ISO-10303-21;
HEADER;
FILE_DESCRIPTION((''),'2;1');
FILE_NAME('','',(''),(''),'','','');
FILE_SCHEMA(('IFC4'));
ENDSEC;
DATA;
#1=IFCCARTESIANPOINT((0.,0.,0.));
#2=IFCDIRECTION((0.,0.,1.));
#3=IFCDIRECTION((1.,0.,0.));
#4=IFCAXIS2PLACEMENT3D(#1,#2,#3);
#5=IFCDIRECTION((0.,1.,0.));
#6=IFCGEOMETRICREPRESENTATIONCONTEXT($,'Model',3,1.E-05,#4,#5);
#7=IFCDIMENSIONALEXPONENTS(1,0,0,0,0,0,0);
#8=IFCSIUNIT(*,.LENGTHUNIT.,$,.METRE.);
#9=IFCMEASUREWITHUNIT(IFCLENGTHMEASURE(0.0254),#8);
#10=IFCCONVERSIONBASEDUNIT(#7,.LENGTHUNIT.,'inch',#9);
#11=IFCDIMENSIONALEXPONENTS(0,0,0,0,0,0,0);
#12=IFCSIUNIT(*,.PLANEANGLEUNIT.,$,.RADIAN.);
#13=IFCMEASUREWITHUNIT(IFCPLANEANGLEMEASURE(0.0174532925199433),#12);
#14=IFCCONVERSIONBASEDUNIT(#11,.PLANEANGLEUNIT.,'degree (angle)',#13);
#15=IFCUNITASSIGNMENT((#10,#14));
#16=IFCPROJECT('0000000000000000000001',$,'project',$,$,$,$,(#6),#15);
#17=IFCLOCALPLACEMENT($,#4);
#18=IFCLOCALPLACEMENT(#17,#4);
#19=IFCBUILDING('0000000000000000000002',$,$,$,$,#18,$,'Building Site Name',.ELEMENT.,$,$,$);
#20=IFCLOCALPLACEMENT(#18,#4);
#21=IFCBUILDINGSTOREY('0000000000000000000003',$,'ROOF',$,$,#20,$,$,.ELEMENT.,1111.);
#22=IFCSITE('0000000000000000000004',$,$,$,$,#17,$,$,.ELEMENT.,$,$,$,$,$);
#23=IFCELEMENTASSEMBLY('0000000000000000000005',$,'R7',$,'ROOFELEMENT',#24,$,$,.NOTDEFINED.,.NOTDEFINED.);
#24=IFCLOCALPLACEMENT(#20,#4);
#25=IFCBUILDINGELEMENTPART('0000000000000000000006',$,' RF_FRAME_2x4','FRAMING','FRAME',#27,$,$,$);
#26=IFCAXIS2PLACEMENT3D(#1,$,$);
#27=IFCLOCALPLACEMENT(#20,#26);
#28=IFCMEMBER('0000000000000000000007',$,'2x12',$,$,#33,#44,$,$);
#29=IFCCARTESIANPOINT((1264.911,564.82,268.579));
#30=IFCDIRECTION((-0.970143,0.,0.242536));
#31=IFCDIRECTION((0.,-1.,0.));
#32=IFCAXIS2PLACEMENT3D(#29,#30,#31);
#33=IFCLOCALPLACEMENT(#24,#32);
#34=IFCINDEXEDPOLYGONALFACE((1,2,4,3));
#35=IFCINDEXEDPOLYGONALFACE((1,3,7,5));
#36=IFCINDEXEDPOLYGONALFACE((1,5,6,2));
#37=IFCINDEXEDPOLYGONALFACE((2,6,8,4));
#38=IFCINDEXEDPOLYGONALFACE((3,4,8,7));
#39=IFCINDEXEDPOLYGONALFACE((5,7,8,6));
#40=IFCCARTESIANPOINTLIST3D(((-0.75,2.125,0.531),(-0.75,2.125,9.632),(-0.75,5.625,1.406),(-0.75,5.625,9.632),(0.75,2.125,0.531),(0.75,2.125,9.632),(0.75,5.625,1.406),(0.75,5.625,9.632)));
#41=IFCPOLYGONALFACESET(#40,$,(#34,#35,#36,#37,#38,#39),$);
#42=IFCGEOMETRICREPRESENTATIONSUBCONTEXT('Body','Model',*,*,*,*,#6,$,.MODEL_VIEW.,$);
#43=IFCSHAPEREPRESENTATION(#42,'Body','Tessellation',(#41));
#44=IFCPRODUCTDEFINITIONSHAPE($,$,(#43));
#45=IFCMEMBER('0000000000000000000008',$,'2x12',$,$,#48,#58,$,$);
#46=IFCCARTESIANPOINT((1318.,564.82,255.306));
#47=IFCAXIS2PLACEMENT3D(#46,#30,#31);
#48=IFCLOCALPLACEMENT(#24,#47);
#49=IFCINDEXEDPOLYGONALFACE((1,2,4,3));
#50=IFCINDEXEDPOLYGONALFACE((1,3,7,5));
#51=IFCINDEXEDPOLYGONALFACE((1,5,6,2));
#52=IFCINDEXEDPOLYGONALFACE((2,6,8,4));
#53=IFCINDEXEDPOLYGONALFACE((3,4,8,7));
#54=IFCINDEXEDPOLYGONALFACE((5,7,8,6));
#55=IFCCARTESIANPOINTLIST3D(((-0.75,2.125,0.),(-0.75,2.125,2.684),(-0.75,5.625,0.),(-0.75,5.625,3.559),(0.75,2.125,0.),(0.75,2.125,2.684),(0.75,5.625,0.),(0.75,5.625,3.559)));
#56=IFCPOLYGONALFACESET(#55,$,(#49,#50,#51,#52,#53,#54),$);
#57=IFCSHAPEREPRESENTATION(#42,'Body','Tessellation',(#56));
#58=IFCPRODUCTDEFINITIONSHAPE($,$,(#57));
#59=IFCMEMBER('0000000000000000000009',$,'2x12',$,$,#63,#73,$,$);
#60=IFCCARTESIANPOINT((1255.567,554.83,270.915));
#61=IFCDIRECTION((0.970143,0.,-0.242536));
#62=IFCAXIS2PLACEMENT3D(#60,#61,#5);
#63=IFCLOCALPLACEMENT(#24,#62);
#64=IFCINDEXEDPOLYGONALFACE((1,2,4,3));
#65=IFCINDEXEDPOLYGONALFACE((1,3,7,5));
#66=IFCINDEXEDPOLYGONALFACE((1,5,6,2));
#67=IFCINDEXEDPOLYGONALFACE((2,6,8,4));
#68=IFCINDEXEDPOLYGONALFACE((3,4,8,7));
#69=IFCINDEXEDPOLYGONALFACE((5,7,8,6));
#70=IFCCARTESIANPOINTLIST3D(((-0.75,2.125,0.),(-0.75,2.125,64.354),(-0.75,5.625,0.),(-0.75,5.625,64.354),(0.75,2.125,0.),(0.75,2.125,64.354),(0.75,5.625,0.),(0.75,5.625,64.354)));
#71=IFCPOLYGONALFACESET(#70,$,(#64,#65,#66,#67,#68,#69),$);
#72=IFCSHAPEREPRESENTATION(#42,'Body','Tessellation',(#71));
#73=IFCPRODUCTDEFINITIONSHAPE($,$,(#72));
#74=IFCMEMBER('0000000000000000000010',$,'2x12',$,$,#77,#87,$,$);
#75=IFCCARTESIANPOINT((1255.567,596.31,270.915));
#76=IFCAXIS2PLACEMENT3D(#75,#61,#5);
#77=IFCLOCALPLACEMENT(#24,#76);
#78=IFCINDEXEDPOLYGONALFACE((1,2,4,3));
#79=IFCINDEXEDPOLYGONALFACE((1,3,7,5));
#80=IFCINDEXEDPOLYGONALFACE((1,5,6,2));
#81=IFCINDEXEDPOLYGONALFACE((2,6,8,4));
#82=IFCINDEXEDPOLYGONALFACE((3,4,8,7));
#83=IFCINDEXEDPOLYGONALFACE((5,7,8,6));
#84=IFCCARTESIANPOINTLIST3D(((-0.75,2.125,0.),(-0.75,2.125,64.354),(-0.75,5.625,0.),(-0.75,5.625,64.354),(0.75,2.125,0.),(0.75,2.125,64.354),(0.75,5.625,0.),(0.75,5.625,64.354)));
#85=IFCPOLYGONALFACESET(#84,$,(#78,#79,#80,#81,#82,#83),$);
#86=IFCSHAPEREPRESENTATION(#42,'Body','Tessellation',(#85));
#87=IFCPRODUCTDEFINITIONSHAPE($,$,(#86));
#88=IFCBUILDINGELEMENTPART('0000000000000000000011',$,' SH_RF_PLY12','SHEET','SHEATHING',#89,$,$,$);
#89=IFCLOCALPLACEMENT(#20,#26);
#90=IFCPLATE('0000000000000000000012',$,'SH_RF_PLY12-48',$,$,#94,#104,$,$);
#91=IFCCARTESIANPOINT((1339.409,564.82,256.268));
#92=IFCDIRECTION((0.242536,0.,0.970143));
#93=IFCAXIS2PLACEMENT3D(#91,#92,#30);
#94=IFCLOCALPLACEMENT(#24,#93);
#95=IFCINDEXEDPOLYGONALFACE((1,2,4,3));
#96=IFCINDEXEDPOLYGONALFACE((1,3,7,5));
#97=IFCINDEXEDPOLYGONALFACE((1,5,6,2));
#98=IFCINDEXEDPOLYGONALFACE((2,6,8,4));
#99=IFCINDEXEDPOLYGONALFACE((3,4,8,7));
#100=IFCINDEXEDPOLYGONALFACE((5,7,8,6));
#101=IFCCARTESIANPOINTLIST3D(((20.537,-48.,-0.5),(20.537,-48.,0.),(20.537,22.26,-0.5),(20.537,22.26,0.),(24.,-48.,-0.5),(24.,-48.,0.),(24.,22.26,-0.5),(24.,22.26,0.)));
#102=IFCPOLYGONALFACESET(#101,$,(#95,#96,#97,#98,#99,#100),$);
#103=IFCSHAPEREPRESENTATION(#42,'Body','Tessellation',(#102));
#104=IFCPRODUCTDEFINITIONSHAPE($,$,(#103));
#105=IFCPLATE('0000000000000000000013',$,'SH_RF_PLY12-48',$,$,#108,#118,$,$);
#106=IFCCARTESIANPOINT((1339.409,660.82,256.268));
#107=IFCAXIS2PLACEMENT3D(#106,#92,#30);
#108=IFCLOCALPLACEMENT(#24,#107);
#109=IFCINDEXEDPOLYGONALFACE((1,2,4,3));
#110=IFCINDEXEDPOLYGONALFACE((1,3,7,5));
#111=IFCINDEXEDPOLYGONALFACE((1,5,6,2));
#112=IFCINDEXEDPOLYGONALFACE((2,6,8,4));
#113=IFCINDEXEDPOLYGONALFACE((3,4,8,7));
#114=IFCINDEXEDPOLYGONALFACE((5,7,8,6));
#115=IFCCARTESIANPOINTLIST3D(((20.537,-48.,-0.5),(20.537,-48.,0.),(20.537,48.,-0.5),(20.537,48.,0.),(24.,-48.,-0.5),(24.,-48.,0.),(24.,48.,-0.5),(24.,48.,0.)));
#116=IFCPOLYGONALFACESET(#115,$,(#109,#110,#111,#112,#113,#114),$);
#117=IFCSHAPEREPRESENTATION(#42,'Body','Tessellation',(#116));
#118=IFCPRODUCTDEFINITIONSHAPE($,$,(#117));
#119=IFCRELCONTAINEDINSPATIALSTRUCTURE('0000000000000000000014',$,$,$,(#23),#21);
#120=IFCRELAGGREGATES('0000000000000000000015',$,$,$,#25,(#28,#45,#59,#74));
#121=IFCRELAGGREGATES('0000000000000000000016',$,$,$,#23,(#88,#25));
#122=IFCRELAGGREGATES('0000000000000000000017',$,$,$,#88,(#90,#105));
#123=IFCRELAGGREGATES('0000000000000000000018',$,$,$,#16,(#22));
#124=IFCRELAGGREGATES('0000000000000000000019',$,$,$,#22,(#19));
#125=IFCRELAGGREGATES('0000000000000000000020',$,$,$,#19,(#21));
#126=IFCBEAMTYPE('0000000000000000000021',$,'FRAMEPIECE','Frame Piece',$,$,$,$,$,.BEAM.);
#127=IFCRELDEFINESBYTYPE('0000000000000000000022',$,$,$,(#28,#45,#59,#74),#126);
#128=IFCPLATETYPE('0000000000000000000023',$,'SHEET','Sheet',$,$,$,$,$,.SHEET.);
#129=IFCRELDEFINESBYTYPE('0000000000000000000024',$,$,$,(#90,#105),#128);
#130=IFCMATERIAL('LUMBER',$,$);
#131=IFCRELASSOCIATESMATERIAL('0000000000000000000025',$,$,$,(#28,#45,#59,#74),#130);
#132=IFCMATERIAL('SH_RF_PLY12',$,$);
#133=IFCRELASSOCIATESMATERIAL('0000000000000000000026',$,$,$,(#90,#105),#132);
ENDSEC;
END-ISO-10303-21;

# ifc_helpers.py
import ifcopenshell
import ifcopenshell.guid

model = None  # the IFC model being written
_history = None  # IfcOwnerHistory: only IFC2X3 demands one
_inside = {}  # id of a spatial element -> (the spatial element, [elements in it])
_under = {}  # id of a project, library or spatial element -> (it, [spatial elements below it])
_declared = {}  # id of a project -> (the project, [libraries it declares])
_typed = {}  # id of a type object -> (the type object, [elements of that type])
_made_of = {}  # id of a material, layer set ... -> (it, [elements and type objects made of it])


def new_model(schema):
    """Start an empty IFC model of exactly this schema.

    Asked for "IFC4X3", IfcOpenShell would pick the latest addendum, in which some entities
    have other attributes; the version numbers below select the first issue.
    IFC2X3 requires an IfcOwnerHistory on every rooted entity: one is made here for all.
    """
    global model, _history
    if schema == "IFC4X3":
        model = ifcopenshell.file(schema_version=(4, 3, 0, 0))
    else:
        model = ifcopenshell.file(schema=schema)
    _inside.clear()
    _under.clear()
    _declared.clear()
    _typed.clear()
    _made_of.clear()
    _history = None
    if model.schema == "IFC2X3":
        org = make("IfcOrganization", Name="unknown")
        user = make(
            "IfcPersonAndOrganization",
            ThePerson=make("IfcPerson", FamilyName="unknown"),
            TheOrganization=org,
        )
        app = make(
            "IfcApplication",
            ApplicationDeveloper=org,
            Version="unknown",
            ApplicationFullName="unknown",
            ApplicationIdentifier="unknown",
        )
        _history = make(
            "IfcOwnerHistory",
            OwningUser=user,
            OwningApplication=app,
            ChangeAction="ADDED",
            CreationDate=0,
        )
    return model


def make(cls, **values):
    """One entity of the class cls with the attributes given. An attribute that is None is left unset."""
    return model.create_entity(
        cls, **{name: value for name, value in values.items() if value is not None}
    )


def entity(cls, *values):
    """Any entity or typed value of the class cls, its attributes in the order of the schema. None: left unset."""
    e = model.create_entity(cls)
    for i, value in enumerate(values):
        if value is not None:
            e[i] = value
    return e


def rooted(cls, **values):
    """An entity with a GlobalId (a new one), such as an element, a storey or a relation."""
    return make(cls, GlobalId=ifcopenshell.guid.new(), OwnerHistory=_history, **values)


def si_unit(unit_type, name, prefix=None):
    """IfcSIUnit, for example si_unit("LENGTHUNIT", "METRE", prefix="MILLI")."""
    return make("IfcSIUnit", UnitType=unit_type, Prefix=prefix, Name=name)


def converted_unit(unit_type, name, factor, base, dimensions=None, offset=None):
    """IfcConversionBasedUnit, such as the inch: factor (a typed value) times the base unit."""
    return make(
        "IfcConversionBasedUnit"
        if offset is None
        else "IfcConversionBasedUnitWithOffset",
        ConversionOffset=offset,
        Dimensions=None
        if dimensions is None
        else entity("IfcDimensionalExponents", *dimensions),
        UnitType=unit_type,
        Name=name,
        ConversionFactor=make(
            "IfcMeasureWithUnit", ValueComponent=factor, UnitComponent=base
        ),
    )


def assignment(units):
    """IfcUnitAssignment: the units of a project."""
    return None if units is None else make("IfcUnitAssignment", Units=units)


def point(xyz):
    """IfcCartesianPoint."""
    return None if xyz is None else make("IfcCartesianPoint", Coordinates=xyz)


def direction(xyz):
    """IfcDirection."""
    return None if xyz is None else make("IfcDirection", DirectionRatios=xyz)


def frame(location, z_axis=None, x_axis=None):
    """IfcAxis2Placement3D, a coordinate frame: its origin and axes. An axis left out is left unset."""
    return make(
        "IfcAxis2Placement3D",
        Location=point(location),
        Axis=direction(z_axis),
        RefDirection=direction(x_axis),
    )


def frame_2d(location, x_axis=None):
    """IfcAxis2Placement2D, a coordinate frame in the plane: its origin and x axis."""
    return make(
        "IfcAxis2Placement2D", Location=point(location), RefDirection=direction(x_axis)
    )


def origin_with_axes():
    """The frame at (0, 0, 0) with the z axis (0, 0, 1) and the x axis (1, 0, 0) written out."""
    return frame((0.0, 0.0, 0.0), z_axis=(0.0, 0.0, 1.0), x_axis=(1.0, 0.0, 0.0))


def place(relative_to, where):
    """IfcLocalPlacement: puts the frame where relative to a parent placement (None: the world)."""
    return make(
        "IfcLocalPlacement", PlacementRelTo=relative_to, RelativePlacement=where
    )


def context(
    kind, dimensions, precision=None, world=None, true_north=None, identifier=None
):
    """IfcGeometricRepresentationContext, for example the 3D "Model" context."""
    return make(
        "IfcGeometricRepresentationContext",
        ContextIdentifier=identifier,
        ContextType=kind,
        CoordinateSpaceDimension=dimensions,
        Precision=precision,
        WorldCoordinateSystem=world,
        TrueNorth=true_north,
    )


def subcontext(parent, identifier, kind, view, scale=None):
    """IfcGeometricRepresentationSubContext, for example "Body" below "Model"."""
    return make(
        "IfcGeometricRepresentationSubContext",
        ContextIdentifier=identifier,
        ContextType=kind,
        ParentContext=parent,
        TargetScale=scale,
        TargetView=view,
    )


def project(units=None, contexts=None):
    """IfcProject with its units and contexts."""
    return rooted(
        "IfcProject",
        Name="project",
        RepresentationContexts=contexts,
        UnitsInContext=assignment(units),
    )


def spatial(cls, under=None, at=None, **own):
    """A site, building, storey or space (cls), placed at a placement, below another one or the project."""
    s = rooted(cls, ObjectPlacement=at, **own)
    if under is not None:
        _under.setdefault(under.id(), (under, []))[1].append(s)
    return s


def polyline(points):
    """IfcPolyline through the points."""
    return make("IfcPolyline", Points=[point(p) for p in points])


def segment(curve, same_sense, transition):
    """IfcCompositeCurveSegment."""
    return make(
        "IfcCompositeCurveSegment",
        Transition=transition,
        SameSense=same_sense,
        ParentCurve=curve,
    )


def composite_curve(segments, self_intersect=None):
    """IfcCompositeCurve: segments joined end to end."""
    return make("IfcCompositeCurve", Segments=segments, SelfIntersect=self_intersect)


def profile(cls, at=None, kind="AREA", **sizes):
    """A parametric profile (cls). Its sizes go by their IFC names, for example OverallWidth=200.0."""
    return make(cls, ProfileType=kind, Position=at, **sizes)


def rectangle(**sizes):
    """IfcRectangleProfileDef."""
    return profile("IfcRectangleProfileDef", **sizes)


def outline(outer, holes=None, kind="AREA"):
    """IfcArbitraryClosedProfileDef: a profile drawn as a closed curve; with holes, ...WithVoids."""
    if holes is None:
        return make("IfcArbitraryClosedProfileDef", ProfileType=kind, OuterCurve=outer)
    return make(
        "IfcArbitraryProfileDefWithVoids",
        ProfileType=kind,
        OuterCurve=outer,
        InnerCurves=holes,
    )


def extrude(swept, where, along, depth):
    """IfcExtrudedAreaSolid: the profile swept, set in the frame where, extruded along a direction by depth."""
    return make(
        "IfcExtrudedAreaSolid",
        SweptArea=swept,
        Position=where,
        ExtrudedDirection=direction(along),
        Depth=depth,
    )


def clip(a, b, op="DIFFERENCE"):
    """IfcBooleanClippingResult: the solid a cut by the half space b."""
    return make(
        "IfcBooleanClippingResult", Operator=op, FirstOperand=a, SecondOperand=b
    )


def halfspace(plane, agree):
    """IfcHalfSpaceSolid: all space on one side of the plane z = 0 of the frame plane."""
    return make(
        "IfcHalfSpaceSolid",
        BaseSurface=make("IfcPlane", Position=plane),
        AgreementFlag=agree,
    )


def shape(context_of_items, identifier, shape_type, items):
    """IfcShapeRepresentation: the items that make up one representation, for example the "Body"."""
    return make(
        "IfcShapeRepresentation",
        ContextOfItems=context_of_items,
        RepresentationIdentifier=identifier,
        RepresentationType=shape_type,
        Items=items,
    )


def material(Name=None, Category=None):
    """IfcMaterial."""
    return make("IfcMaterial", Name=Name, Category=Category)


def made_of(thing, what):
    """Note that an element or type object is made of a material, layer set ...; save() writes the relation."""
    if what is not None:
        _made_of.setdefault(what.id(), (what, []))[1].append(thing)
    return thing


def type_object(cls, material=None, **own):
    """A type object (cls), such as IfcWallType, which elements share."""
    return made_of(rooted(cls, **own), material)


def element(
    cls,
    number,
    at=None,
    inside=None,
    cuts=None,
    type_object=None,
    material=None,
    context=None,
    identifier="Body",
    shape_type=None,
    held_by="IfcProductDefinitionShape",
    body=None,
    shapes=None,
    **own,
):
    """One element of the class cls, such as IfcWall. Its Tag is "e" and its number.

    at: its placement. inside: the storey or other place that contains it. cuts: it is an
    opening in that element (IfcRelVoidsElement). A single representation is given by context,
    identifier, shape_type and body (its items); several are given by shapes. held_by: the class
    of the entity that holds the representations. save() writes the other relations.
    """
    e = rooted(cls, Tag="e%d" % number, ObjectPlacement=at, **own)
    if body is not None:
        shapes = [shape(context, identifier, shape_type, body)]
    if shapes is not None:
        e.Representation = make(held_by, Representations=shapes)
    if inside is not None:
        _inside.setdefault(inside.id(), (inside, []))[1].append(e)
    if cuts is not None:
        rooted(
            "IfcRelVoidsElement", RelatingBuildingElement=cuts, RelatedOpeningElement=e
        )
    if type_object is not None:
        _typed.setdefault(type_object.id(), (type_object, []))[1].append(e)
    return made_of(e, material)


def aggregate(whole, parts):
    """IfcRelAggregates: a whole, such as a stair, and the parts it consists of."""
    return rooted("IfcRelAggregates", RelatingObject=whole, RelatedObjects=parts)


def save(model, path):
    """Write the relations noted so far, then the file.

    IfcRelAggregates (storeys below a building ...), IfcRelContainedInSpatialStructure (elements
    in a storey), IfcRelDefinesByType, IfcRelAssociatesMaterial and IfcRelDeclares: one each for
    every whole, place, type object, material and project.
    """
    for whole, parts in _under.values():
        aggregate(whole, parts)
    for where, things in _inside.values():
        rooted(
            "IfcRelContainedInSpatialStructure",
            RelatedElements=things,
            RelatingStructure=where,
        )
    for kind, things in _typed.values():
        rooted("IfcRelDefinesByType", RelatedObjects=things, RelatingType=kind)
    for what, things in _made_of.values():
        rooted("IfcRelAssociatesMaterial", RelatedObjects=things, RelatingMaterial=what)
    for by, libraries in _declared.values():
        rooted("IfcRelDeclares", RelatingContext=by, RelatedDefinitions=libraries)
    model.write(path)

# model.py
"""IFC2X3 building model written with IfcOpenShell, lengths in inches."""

from ifc_helpers import new_model, entity, si_unit, converted_unit, direction, frame, frame_2d, origin_with_axes, place, context, subcontext, project, spatial, polyline, segment, composite_curve, rectangle, outline, extrude, clip, halfspace, material, type_object, element, aggregate, save


model = new_model("IFC2X3")

# Units and contexts
model_context = context("Model", 3, precision=1e-05, world=origin_with_axes(), true_north=direction((0.0, 1.0, 0.0)))
body_context = subcontext(model_context, "Body", "Model", "MODEL_VIEW")
ifc_project = project(units=[converted_unit("LENGTHUNIT", "inch", entity("IfcLengthMeasure", 0.0254), si_unit("LENGTHUNIT", "METRE"), dimensions=[1, 0, 0, 0, 0, 0, 0]), converted_unit("PLANEANGLEUNIT", "degree (angle)", entity("IfcPlaneAngleMeasure", 0.0174532925199433), si_unit("PLANEANGLEUNIT", "RADIAN"), dimensions=[0, 0, 0, 0, 0, 0, 0])], contexts=[model_context])

# Site, building, storey
site_placement = place(None, origin_with_axes())
site = spatial("IfcSite", under=ifc_project, at=site_placement, CompositionType="ELEMENT")
building_placement = place(site_placement, origin_with_axes())
building = spatial("IfcBuilding", under=site, at=building_placement, LongName="Building Site Name", CompositionType="ELEMENT")
storey_placement = place(building_placement, origin_with_axes())
storey = spatial("IfcBuildingStorey", under=building, at=storey_placement, Name="ROOF", CompositionType="ELEMENT", Elevation=1111.0)

# Element assembly, building element parts, members, plates
assembly_placement = place(storey_placement, origin_with_axes())
assembly = element("IfcElementAssembly", 1, at=assembly_placement, inside=storey, Name="R7", ObjectType="ROOFELEMENT", AssemblyPlace="NOTDEFINED", PredefinedType="NOTDEFINED")
building_element_part_1 = element("IfcBuildingElementPart", 2, Name=" RF_FRAME_2x4", Description="FRAMING", ObjectType="FRAME")
ifc_material_1 = material(Name="LUMBER")
beam_type = type_object("IfcBeamType", Name="FRAMEPIECE", Description="Frame Piece", PredefinedType="BEAM")
member_1_placement = place(assembly_placement, frame((1264.911, 564.82, 268.579), z_axis=(-0.970143, 0.0, 0.242536), x_axis=(0.0, -1.0, 0.0)))
member_1 = element("IfcMember", 3, at=member_1_placement, type_object=beam_type, material=ifc_material_1, Name="2x12", context=body_context, shape_type="Clipping", body=[
    clip(extrude(rectangle(XDim=3.5, YDim=1.5, at=frame_2d((0.0, 3.875), x_axis=(0.0, -1.0))), frame((0.0, 0.0, -4.019), z_axis=(0.0, 0.0, 1.0), x_axis=(1.0, 0.0, 0.0)), (0.0, 0.0, 1.0), 13.651), halfspace(frame((0.75, 2.125, 0.531), z_axis=(0.0, -0.242536, 0.970143), x_axis=(0.0, 0.970143, 0.242536)), True)),
])
member_2_placement = place(assembly_placement, frame((1318.0, 564.82, 255.306), z_axis=(-0.970143, 0.0, 0.242536), x_axis=(0.0, -1.0, 0.0)))
member_2 = element("IfcMember", 4, at=member_2_placement, type_object=beam_type, material=ifc_material_1, Name="2x12", context=body_context, shape_type="Clipping", body=[
    clip(extrude(rectangle(XDim=3.5, YDim=1.5, at=frame_2d((0.0, 3.875), x_axis=(0.0, -1.0))), frame((0.0, 0.0, 0.0), z_axis=(0.0, 0.0, 1.0), x_axis=(1.0, 0.0, 0.0)), (0.0, 0.0, 1.0), 5.338), halfspace(frame((-0.75, 2.125, 2.684), z_axis=(0.0, 0.242536, -0.970143), x_axis=(0.0, -0.970143, -0.242536)), True)),
])
member_3_placement = place(assembly_placement, frame((1255.567, 554.83, 270.915), z_axis=(0.970143, 0.0, -0.242536), x_axis=(0.0, 1.0, 0.0)))
member_3 = element("IfcMember", 5, at=member_3_placement, type_object=beam_type, material=ifc_material_1, Name="2x12", context=body_context, shape_type="SweptSolid", body=[
    extrude(rectangle(XDim=3.5, YDim=1.5, at=frame_2d((0.0, 3.875), x_axis=(0.0, -1.0))), frame((0.0, 0.0, 0.0), z_axis=(0.0, 0.0, 1.0), x_axis=(1.0, 0.0, 0.0)), (0.0, 0.0, 1.0), 64.354),
])
member_4_placement = place(assembly_placement, frame((1255.567, 596.31, 270.915), z_axis=(0.970143, 0.0, -0.242536), x_axis=(0.0, 1.0, 0.0)))
member_4 = element("IfcMember", 6, at=member_4_placement, type_object=beam_type, material=ifc_material_1, Name="2x12", context=body_context, shape_type="SweptSolid", body=[
    extrude(rectangle(XDim=3.5, YDim=1.5, at=frame_2d((0.0, 3.875), x_axis=(0.0, -1.0))), frame((0.0, 0.0, 0.0), z_axis=(0.0, 0.0, 1.0), x_axis=(1.0, 0.0, 0.0)), (0.0, 0.0, 1.0), 64.354),
])
aggregate(building_element_part_1, [member_1, member_2, member_3, member_4])
building_element_part_2 = element("IfcBuildingElementPart", 7, Name=" SH_RF_PLY12", Description="SHEET", ObjectType="SHEATHING")
aggregate(assembly, [building_element_part_2, building_element_part_1])
ifc_material_2 = material(Name="SH_RF_PLY12")
plate_type = type_object("IfcPlateType", Name="SHEET", Description="Sheet", PredefinedType="SHEET")
plate_1_placement = place(assembly_placement, frame((1339.409, 564.82, 256.268), z_axis=(0.242536, 0.0, 0.970143), x_axis=(-0.970143, 0.0, 0.242536)))
plate_1 = element("IfcPlate", 8, at=plate_1_placement, type_object=plate_type, material=ifc_material_2, Name="SH_RF_PLY12-48", context=body_context, shape_type="SweptSolid", body=[
    extrude(outline(composite_curve([segment(polyline([(-24.0, -0.5), (-20.537, -0.5), (-20.537, 0.0), (-24.0, 0.0), (-24.0, -0.5)]), True, "CONTINUOUS")], self_intersect=False)), frame((0.0, -48.0, 0.0), z_axis=(0.0, 1.0, 0.0), x_axis=(-1.0, 0.0, 0.0)), (0.0, 0.0, 1.0), 70.26),
])
plate_2_placement = place(assembly_placement, frame((1339.409, 660.82, 256.268), z_axis=(0.242536, 0.0, 0.970143), x_axis=(-0.970143, 0.0, 0.242536)))
plate_2 = element("IfcPlate", 9, at=plate_2_placement, type_object=plate_type, material=ifc_material_2, Name="SH_RF_PLY12-48", context=body_context, shape_type="SweptSolid", body=[
    extrude(outline(composite_curve([segment(polyline([(-24.0, -0.5), (-20.537, -0.5), (-20.537, 0.0), (-24.0, 0.0), (-24.0, -0.5)]), True, "CONTINUOUS")], self_intersect=False)), frame((0.0, -48.0, 0.0), z_axis=(0.0, 1.0, 0.0), x_axis=(-1.0, 0.0, 0.0)), (0.0, 0.0, 1.0), 96.0),
])
aggregate(building_element_part_2, [plate_1, plate_2])

save(model, "model.ifc")
